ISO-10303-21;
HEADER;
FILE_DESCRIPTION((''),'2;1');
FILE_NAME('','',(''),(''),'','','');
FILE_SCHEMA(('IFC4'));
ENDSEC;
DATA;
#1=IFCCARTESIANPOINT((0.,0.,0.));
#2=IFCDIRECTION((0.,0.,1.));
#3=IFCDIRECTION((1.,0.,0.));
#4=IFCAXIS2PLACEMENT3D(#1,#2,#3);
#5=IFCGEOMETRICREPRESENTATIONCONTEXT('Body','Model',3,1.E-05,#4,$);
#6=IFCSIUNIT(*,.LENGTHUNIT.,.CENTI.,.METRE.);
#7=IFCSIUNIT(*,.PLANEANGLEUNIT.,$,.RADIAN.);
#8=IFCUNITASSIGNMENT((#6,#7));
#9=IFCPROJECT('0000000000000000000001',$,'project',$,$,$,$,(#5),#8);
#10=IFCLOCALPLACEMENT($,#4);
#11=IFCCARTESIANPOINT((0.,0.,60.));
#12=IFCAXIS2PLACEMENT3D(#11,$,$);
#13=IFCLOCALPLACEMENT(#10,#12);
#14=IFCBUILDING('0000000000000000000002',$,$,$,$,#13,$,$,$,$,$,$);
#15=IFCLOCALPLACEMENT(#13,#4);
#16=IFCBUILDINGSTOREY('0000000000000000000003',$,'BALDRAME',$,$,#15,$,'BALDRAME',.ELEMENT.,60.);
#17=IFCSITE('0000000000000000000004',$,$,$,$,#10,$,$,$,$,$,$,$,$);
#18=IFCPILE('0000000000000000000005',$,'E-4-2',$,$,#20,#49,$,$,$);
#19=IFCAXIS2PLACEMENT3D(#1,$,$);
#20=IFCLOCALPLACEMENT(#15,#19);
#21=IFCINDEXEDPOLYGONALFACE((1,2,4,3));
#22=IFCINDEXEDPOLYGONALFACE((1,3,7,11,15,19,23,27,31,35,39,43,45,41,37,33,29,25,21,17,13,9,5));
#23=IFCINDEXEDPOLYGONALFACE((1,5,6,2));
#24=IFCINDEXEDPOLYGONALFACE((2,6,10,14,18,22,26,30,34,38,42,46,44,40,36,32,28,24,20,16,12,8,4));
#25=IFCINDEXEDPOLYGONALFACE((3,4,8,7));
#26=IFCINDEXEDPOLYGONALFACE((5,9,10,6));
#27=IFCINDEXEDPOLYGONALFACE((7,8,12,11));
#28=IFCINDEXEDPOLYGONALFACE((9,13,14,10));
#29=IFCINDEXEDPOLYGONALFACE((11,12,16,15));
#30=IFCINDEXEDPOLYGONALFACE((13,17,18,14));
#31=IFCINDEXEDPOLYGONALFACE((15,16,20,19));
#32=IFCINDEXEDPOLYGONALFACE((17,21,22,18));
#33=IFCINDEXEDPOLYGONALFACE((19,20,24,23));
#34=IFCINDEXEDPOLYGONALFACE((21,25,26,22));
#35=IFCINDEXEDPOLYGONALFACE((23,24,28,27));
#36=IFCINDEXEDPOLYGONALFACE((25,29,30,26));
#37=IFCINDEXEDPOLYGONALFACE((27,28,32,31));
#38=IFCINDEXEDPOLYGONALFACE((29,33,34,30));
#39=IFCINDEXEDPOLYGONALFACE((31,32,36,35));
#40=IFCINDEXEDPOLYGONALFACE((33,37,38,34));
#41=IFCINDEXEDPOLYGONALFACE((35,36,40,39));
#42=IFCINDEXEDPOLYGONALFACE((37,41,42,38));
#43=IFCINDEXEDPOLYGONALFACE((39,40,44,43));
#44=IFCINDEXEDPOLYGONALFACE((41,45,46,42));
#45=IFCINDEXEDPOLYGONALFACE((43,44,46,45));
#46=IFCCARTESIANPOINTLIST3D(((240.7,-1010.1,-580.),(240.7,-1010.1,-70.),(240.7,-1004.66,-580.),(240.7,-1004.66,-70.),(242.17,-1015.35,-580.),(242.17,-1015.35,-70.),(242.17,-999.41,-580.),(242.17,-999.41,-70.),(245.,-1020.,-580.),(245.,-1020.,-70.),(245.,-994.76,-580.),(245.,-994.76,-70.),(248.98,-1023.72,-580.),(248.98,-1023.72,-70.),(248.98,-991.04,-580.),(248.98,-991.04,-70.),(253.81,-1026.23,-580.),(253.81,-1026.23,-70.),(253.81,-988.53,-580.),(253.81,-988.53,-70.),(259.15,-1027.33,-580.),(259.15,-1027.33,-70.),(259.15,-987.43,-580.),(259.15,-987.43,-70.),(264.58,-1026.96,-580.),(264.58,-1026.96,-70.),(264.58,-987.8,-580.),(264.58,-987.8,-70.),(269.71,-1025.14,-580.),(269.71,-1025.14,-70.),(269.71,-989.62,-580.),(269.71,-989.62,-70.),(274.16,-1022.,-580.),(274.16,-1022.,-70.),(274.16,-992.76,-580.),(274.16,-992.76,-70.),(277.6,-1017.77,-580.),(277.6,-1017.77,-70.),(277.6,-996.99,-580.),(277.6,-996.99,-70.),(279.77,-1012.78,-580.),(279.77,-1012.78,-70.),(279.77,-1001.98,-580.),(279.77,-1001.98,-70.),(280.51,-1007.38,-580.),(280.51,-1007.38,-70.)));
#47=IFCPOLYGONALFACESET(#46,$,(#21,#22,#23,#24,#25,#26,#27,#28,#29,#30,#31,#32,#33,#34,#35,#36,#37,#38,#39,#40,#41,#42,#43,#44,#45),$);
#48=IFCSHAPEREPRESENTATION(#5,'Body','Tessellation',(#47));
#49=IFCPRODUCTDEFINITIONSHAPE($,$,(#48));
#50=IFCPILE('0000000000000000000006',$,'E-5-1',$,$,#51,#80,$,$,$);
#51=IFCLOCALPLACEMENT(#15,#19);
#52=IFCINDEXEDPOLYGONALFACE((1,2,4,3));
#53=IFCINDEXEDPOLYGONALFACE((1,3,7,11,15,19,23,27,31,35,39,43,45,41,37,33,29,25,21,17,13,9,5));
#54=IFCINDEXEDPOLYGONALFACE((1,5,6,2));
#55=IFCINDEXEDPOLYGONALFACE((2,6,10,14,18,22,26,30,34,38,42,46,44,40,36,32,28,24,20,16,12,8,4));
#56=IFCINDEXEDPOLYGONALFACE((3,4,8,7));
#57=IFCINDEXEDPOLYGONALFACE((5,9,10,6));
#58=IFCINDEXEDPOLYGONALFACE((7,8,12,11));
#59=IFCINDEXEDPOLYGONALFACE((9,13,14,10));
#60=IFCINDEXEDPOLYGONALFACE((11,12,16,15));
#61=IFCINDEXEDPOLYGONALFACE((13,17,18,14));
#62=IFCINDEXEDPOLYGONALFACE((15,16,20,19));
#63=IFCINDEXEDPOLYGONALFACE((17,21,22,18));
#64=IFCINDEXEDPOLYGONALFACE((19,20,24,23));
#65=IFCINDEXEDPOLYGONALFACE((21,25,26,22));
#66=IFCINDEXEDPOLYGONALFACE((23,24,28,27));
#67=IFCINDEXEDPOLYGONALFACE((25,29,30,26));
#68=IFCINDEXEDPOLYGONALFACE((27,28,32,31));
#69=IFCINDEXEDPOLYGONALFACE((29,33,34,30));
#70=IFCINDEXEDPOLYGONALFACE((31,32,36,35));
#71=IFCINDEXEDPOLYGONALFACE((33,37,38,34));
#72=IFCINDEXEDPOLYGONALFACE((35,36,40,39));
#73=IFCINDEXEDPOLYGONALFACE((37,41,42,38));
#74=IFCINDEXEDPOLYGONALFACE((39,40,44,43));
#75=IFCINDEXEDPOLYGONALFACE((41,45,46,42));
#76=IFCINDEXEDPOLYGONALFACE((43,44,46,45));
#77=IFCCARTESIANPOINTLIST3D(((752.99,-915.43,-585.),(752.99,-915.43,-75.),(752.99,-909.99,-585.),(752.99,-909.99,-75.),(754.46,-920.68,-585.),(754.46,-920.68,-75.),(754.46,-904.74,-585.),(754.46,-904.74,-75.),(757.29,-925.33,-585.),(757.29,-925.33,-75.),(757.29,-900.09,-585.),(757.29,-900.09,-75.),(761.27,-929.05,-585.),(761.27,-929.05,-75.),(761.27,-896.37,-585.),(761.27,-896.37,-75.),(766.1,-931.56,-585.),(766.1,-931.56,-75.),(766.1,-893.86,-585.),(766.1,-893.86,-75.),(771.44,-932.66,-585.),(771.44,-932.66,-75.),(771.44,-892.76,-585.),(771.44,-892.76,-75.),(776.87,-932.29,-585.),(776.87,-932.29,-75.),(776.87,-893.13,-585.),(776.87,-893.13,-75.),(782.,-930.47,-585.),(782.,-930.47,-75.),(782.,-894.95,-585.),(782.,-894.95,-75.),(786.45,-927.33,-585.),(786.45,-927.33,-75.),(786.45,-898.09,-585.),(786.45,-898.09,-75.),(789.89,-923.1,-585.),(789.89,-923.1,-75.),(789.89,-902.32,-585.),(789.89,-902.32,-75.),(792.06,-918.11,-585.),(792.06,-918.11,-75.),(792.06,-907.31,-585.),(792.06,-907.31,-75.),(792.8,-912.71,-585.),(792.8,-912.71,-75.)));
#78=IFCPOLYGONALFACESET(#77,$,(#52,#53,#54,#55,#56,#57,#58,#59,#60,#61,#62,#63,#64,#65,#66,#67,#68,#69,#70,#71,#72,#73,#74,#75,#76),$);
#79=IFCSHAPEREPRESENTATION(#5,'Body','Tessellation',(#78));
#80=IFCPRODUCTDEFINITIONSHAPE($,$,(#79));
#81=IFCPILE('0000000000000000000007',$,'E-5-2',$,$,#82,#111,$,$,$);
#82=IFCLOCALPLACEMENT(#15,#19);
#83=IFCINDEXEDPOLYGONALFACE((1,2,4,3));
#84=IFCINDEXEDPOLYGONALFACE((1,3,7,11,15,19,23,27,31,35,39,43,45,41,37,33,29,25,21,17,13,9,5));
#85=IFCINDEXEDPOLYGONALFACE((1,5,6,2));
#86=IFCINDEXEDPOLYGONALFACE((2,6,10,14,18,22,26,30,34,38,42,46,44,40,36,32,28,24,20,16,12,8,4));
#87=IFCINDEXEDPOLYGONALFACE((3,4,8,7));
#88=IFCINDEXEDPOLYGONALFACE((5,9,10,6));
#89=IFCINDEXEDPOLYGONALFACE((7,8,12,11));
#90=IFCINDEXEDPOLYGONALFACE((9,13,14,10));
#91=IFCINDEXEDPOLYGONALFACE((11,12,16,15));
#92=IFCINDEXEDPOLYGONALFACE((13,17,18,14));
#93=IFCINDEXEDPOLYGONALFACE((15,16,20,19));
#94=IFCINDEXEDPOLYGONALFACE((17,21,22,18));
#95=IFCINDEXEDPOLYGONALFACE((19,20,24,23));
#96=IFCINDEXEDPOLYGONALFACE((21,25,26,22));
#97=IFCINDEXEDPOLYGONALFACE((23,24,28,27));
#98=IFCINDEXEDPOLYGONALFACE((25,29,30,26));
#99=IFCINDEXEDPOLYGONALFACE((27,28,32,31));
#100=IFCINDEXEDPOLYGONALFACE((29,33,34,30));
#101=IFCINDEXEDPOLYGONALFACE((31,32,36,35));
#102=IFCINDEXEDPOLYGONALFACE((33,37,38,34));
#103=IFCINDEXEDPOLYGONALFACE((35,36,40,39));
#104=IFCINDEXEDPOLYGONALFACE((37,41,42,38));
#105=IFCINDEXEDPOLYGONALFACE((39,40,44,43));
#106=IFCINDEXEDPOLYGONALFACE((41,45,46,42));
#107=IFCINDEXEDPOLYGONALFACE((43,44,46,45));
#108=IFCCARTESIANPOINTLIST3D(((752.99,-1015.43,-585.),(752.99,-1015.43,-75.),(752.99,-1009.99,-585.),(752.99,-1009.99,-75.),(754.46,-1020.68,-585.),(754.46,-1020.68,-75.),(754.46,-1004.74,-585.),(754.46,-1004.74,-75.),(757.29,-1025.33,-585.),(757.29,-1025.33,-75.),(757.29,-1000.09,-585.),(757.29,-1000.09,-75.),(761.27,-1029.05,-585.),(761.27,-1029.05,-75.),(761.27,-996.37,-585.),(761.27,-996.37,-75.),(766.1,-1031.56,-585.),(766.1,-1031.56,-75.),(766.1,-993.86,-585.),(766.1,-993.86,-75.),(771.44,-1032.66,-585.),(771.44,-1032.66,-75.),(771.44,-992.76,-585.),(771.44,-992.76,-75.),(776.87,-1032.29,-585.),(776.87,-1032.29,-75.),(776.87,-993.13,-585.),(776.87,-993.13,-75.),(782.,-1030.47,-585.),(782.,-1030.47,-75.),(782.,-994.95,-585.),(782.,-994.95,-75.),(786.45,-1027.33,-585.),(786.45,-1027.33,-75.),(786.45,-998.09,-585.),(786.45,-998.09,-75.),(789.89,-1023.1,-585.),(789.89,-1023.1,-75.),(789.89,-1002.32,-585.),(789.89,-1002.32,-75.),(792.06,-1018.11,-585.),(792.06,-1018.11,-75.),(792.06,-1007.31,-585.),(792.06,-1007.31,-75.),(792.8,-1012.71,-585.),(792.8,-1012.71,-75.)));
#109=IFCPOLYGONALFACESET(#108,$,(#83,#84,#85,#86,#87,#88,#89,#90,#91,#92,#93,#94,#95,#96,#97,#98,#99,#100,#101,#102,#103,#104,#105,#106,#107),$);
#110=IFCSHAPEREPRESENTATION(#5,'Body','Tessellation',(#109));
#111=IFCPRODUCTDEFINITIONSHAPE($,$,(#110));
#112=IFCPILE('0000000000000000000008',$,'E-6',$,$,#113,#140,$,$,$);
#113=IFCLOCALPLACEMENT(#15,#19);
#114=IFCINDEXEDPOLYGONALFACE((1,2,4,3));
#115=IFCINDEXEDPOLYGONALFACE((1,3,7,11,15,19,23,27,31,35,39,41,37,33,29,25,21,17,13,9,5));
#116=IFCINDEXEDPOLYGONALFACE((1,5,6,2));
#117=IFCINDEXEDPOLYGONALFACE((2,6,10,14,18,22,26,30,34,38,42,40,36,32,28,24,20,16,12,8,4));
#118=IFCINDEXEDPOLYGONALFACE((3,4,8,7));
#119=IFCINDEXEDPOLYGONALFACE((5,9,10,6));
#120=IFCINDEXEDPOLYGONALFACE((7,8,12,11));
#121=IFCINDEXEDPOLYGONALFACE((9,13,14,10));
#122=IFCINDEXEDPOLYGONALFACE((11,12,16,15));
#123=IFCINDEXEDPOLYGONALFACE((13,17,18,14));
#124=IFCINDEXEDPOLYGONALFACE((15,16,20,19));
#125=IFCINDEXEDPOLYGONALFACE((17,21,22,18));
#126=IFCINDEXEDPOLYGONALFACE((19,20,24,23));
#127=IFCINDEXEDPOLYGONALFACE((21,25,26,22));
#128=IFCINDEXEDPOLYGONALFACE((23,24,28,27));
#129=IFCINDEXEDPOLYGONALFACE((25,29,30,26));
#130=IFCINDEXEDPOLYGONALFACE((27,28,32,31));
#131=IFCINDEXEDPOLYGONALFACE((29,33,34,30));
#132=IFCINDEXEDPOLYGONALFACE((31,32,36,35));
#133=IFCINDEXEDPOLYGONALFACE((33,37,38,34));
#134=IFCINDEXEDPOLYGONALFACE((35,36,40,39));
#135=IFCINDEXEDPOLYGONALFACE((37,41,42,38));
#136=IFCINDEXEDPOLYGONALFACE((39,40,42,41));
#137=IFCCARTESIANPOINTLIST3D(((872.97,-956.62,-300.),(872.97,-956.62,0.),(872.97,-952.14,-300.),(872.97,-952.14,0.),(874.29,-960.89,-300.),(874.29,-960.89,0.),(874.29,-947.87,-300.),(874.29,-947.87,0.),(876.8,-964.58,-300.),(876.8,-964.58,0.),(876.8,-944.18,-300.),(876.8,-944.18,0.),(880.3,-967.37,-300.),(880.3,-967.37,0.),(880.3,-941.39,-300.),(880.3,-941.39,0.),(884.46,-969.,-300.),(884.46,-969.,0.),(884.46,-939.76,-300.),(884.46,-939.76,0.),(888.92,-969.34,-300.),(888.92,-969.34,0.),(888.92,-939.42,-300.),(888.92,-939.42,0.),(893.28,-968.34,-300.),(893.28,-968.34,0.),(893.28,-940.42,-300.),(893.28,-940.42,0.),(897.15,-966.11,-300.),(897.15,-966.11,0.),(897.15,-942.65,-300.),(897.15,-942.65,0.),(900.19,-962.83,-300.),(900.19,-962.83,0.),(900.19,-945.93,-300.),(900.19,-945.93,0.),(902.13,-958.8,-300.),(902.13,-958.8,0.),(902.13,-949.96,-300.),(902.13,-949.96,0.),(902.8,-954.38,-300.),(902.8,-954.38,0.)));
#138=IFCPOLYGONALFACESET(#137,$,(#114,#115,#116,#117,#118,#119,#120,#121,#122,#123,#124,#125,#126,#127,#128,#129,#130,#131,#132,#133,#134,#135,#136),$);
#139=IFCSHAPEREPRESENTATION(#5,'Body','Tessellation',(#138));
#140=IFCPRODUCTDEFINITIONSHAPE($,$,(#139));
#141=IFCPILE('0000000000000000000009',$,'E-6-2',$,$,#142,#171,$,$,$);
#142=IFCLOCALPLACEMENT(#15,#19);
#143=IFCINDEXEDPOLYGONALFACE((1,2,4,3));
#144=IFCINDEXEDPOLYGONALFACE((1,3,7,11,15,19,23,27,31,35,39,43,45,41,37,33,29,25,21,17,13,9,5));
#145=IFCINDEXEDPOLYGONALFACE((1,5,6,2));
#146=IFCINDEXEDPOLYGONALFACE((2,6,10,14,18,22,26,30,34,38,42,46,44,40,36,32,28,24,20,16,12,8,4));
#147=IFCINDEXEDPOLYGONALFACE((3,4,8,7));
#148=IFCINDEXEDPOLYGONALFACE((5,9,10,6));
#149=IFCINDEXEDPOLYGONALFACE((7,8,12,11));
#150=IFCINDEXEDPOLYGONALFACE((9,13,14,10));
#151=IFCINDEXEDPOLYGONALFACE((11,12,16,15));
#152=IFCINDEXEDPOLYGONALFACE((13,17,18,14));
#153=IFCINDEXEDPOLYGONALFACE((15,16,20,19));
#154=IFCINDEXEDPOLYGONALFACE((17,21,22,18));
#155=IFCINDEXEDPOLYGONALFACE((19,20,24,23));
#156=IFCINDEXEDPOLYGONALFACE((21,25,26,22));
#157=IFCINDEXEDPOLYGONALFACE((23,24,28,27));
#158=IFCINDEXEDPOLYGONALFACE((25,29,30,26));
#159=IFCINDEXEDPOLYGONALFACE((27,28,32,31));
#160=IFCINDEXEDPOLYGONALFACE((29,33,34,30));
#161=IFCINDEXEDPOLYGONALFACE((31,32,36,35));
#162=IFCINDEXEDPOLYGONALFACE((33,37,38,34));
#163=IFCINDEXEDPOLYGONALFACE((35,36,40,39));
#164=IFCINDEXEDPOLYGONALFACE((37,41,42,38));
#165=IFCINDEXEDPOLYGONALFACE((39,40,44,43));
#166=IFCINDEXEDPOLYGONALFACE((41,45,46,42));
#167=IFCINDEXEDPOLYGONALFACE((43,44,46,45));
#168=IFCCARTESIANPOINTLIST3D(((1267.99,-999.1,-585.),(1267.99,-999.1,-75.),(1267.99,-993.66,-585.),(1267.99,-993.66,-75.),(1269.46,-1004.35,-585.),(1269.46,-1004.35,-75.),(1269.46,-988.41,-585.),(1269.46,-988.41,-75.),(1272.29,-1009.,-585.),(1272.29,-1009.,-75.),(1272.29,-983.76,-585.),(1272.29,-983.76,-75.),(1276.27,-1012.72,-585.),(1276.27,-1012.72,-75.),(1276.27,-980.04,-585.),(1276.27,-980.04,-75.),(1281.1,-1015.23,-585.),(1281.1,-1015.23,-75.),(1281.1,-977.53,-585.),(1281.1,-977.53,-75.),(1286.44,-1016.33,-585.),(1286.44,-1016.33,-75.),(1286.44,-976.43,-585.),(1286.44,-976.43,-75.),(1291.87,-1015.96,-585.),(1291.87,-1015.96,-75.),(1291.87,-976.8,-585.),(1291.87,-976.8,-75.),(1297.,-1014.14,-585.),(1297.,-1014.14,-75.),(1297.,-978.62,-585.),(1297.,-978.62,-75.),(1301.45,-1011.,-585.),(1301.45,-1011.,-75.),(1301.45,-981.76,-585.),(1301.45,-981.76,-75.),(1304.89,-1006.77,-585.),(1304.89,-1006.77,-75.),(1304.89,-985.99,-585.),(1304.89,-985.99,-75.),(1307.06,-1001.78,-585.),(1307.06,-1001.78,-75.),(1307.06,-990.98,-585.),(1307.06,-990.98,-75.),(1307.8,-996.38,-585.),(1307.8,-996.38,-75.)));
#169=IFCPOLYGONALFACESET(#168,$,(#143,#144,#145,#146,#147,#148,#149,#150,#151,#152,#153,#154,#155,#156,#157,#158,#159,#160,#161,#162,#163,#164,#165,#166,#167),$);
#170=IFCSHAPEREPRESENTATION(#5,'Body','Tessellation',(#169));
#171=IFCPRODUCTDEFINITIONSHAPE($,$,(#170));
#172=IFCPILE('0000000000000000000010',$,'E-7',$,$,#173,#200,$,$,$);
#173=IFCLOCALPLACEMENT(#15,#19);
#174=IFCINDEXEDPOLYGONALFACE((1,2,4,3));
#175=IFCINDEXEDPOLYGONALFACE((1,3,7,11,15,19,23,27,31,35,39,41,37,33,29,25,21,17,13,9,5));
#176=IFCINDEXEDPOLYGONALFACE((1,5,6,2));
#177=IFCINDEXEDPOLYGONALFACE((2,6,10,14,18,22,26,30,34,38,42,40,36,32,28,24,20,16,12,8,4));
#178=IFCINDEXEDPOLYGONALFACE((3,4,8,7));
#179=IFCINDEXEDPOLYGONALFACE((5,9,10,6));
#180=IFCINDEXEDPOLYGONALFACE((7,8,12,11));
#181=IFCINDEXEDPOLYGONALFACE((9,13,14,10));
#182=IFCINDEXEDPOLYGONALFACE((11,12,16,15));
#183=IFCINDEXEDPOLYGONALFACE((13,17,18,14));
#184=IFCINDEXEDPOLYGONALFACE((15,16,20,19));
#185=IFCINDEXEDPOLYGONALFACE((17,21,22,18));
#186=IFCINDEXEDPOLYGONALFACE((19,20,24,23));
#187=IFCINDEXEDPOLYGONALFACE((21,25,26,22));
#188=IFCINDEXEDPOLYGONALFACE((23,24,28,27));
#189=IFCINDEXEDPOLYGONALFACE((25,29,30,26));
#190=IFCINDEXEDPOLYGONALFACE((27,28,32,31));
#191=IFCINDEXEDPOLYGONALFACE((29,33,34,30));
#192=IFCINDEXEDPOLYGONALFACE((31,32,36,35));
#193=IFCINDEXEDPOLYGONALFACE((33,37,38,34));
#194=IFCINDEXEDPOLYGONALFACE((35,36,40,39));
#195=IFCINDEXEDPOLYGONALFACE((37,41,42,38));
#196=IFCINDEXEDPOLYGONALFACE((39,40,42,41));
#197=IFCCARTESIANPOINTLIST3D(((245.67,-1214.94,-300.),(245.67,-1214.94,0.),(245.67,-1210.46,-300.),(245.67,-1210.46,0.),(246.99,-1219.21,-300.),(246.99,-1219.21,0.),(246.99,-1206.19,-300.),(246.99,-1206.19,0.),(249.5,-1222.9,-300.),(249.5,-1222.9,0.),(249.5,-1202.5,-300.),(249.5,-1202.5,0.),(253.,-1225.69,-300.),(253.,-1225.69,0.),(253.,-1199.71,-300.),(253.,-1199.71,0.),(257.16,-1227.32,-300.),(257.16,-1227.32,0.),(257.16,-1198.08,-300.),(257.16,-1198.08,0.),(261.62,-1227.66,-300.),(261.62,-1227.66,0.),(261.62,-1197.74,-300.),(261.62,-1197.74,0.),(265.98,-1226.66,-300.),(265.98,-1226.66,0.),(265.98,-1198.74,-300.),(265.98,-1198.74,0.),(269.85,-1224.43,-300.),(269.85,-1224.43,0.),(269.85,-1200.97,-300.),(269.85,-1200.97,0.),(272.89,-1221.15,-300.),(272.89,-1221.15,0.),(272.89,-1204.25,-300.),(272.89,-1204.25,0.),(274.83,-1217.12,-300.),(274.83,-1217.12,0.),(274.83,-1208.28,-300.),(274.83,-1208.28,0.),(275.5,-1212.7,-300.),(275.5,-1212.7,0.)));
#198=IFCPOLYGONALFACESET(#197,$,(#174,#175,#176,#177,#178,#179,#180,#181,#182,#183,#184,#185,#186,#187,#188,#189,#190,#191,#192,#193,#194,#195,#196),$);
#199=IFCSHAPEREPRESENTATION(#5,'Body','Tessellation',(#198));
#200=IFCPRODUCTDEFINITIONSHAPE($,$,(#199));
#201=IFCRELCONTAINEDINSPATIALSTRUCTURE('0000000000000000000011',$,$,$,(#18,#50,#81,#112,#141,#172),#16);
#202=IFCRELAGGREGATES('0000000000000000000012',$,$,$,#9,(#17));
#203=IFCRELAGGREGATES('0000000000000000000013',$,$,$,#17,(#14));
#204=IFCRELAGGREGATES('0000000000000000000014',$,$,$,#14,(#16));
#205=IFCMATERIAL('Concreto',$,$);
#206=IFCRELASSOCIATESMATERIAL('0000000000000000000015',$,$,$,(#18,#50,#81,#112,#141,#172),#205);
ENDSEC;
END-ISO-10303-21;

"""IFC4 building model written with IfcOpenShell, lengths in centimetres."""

from ifc_helpers import new_model, si_unit, frame, origin_with_axes, origin_2d_with_axis, place, context, project, spatial, circle, extrude, material, element, save


model = new_model("IFC4")

# Units and contexts
model_context = context("Model", 3, precision=1e-05, world=origin_with_axes(), identifier="Body")
ifc_project = project(units=[si_unit("LENGTHUNIT", "METRE", prefix="CENTI"), si_unit("PLANEANGLEUNIT", "RADIAN")], contexts=[model_context])

# Site, building, storey
site_placement = place(None, origin_with_axes())
site = spatial("IfcSite", under=ifc_project, at=site_placement)
building_placement = place(site_placement, frame((0.0, 0.0, 60.0)))
building = spatial("IfcBuilding", under=site, at=building_placement)
storey_placement = place(building_placement, origin_with_axes())
storey = spatial("IfcBuildingStorey", under=building, at=storey_placement, Name="BALDRAME", LongName="BALDRAME", CompositionType="ELEMENT", Elevation=60.0)

# Piles
ifc_material = material(Name="Concreto")
for number, where, z_axis, x_axis, name in (
    (1, (260.51, -1007.38, -70.0), (0.0, 0.0, 1.0), (1.0, 0.0, 0.0), "E-4-2"),
    (2, (772.8, -912.71, -75.0), (0.0, 0.0, 1.0), (1.0, 0.0, 0.0), "E-5-1"),
    (3, (772.8, -1012.71, -75.0), (0.0, 0.0, 1.0), (1.0, 0.0, 0.0), "E-5-2"),
):
    element("IfcPile", number, at=place(storey_placement, frame(where, z_axis=z_axis, x_axis=x_axis)), inside=storey, material=ifc_material, Name=name, context=model_context, shape_type="SweptSolid", body=[
        extrude(circle(Radius=20.0, at=origin_2d_with_axis()), frame((0.0, 0.0, -510.0), z_axis=(0.0, 0.0, 1.0), x_axis=(1.0, 0.0, 0.0)), (0.0, 0.0, 1.0), 510.0),
    ])
pile_1_placement = place(storey_placement, frame((887.8, -954.38, 0.0), z_axis=(0.0, 0.0, 1.0), x_axis=(1.0, 0.0, 0.0)))
element("IfcPile", 4, at=pile_1_placement, inside=storey, material=ifc_material, Name="E-6", context=model_context, shape_type="SolidModel", body=[
    extrude(circle(Radius=15.0, at=origin_2d_with_axis()), frame((0.0, 0.0, -300.0), z_axis=(0.0, 0.0, 1.0), x_axis=(1.0, 0.0, 0.0)), (0.0, 0.0, 1.0), 300.0),
])
pile_2_placement = place(storey_placement, frame((1287.8, -996.38, -75.0), z_axis=(0.0, 0.0, 1.0), x_axis=(1.0, 0.0, 0.0)))
element("IfcPile", 5, at=pile_2_placement, inside=storey, material=ifc_material, Name="E-6-2", context=model_context, shape_type="SweptSolid", body=[
    extrude(circle(Radius=20.0, at=origin_2d_with_axis()), frame((0.0, 0.0, -510.0), z_axis=(0.0, 0.0, 1.0), x_axis=(1.0, 0.0, 0.0)), (0.0, 0.0, 1.0), 510.0),
])
pile_3_placement = place(storey_placement, frame((260.5, -1212.7, 0.0), z_axis=(0.0, 0.0, 1.0), x_axis=(1.0, 0.0, 0.0)))
element("IfcPile", 6, at=pile_3_placement, inside=storey, material=ifc_material, Name="E-7", context=model_context, shape_type="SolidModel", body=[
    extrude(circle(Radius=15.0, at=origin_2d_with_axis()), frame((0.0, 0.0, -300.0), z_axis=(0.0, 0.0, 1.0), x_axis=(1.0, 0.0, 0.0)), (0.0, 0.0, 1.0), 300.0),
])

save(model, "model.ifc")
